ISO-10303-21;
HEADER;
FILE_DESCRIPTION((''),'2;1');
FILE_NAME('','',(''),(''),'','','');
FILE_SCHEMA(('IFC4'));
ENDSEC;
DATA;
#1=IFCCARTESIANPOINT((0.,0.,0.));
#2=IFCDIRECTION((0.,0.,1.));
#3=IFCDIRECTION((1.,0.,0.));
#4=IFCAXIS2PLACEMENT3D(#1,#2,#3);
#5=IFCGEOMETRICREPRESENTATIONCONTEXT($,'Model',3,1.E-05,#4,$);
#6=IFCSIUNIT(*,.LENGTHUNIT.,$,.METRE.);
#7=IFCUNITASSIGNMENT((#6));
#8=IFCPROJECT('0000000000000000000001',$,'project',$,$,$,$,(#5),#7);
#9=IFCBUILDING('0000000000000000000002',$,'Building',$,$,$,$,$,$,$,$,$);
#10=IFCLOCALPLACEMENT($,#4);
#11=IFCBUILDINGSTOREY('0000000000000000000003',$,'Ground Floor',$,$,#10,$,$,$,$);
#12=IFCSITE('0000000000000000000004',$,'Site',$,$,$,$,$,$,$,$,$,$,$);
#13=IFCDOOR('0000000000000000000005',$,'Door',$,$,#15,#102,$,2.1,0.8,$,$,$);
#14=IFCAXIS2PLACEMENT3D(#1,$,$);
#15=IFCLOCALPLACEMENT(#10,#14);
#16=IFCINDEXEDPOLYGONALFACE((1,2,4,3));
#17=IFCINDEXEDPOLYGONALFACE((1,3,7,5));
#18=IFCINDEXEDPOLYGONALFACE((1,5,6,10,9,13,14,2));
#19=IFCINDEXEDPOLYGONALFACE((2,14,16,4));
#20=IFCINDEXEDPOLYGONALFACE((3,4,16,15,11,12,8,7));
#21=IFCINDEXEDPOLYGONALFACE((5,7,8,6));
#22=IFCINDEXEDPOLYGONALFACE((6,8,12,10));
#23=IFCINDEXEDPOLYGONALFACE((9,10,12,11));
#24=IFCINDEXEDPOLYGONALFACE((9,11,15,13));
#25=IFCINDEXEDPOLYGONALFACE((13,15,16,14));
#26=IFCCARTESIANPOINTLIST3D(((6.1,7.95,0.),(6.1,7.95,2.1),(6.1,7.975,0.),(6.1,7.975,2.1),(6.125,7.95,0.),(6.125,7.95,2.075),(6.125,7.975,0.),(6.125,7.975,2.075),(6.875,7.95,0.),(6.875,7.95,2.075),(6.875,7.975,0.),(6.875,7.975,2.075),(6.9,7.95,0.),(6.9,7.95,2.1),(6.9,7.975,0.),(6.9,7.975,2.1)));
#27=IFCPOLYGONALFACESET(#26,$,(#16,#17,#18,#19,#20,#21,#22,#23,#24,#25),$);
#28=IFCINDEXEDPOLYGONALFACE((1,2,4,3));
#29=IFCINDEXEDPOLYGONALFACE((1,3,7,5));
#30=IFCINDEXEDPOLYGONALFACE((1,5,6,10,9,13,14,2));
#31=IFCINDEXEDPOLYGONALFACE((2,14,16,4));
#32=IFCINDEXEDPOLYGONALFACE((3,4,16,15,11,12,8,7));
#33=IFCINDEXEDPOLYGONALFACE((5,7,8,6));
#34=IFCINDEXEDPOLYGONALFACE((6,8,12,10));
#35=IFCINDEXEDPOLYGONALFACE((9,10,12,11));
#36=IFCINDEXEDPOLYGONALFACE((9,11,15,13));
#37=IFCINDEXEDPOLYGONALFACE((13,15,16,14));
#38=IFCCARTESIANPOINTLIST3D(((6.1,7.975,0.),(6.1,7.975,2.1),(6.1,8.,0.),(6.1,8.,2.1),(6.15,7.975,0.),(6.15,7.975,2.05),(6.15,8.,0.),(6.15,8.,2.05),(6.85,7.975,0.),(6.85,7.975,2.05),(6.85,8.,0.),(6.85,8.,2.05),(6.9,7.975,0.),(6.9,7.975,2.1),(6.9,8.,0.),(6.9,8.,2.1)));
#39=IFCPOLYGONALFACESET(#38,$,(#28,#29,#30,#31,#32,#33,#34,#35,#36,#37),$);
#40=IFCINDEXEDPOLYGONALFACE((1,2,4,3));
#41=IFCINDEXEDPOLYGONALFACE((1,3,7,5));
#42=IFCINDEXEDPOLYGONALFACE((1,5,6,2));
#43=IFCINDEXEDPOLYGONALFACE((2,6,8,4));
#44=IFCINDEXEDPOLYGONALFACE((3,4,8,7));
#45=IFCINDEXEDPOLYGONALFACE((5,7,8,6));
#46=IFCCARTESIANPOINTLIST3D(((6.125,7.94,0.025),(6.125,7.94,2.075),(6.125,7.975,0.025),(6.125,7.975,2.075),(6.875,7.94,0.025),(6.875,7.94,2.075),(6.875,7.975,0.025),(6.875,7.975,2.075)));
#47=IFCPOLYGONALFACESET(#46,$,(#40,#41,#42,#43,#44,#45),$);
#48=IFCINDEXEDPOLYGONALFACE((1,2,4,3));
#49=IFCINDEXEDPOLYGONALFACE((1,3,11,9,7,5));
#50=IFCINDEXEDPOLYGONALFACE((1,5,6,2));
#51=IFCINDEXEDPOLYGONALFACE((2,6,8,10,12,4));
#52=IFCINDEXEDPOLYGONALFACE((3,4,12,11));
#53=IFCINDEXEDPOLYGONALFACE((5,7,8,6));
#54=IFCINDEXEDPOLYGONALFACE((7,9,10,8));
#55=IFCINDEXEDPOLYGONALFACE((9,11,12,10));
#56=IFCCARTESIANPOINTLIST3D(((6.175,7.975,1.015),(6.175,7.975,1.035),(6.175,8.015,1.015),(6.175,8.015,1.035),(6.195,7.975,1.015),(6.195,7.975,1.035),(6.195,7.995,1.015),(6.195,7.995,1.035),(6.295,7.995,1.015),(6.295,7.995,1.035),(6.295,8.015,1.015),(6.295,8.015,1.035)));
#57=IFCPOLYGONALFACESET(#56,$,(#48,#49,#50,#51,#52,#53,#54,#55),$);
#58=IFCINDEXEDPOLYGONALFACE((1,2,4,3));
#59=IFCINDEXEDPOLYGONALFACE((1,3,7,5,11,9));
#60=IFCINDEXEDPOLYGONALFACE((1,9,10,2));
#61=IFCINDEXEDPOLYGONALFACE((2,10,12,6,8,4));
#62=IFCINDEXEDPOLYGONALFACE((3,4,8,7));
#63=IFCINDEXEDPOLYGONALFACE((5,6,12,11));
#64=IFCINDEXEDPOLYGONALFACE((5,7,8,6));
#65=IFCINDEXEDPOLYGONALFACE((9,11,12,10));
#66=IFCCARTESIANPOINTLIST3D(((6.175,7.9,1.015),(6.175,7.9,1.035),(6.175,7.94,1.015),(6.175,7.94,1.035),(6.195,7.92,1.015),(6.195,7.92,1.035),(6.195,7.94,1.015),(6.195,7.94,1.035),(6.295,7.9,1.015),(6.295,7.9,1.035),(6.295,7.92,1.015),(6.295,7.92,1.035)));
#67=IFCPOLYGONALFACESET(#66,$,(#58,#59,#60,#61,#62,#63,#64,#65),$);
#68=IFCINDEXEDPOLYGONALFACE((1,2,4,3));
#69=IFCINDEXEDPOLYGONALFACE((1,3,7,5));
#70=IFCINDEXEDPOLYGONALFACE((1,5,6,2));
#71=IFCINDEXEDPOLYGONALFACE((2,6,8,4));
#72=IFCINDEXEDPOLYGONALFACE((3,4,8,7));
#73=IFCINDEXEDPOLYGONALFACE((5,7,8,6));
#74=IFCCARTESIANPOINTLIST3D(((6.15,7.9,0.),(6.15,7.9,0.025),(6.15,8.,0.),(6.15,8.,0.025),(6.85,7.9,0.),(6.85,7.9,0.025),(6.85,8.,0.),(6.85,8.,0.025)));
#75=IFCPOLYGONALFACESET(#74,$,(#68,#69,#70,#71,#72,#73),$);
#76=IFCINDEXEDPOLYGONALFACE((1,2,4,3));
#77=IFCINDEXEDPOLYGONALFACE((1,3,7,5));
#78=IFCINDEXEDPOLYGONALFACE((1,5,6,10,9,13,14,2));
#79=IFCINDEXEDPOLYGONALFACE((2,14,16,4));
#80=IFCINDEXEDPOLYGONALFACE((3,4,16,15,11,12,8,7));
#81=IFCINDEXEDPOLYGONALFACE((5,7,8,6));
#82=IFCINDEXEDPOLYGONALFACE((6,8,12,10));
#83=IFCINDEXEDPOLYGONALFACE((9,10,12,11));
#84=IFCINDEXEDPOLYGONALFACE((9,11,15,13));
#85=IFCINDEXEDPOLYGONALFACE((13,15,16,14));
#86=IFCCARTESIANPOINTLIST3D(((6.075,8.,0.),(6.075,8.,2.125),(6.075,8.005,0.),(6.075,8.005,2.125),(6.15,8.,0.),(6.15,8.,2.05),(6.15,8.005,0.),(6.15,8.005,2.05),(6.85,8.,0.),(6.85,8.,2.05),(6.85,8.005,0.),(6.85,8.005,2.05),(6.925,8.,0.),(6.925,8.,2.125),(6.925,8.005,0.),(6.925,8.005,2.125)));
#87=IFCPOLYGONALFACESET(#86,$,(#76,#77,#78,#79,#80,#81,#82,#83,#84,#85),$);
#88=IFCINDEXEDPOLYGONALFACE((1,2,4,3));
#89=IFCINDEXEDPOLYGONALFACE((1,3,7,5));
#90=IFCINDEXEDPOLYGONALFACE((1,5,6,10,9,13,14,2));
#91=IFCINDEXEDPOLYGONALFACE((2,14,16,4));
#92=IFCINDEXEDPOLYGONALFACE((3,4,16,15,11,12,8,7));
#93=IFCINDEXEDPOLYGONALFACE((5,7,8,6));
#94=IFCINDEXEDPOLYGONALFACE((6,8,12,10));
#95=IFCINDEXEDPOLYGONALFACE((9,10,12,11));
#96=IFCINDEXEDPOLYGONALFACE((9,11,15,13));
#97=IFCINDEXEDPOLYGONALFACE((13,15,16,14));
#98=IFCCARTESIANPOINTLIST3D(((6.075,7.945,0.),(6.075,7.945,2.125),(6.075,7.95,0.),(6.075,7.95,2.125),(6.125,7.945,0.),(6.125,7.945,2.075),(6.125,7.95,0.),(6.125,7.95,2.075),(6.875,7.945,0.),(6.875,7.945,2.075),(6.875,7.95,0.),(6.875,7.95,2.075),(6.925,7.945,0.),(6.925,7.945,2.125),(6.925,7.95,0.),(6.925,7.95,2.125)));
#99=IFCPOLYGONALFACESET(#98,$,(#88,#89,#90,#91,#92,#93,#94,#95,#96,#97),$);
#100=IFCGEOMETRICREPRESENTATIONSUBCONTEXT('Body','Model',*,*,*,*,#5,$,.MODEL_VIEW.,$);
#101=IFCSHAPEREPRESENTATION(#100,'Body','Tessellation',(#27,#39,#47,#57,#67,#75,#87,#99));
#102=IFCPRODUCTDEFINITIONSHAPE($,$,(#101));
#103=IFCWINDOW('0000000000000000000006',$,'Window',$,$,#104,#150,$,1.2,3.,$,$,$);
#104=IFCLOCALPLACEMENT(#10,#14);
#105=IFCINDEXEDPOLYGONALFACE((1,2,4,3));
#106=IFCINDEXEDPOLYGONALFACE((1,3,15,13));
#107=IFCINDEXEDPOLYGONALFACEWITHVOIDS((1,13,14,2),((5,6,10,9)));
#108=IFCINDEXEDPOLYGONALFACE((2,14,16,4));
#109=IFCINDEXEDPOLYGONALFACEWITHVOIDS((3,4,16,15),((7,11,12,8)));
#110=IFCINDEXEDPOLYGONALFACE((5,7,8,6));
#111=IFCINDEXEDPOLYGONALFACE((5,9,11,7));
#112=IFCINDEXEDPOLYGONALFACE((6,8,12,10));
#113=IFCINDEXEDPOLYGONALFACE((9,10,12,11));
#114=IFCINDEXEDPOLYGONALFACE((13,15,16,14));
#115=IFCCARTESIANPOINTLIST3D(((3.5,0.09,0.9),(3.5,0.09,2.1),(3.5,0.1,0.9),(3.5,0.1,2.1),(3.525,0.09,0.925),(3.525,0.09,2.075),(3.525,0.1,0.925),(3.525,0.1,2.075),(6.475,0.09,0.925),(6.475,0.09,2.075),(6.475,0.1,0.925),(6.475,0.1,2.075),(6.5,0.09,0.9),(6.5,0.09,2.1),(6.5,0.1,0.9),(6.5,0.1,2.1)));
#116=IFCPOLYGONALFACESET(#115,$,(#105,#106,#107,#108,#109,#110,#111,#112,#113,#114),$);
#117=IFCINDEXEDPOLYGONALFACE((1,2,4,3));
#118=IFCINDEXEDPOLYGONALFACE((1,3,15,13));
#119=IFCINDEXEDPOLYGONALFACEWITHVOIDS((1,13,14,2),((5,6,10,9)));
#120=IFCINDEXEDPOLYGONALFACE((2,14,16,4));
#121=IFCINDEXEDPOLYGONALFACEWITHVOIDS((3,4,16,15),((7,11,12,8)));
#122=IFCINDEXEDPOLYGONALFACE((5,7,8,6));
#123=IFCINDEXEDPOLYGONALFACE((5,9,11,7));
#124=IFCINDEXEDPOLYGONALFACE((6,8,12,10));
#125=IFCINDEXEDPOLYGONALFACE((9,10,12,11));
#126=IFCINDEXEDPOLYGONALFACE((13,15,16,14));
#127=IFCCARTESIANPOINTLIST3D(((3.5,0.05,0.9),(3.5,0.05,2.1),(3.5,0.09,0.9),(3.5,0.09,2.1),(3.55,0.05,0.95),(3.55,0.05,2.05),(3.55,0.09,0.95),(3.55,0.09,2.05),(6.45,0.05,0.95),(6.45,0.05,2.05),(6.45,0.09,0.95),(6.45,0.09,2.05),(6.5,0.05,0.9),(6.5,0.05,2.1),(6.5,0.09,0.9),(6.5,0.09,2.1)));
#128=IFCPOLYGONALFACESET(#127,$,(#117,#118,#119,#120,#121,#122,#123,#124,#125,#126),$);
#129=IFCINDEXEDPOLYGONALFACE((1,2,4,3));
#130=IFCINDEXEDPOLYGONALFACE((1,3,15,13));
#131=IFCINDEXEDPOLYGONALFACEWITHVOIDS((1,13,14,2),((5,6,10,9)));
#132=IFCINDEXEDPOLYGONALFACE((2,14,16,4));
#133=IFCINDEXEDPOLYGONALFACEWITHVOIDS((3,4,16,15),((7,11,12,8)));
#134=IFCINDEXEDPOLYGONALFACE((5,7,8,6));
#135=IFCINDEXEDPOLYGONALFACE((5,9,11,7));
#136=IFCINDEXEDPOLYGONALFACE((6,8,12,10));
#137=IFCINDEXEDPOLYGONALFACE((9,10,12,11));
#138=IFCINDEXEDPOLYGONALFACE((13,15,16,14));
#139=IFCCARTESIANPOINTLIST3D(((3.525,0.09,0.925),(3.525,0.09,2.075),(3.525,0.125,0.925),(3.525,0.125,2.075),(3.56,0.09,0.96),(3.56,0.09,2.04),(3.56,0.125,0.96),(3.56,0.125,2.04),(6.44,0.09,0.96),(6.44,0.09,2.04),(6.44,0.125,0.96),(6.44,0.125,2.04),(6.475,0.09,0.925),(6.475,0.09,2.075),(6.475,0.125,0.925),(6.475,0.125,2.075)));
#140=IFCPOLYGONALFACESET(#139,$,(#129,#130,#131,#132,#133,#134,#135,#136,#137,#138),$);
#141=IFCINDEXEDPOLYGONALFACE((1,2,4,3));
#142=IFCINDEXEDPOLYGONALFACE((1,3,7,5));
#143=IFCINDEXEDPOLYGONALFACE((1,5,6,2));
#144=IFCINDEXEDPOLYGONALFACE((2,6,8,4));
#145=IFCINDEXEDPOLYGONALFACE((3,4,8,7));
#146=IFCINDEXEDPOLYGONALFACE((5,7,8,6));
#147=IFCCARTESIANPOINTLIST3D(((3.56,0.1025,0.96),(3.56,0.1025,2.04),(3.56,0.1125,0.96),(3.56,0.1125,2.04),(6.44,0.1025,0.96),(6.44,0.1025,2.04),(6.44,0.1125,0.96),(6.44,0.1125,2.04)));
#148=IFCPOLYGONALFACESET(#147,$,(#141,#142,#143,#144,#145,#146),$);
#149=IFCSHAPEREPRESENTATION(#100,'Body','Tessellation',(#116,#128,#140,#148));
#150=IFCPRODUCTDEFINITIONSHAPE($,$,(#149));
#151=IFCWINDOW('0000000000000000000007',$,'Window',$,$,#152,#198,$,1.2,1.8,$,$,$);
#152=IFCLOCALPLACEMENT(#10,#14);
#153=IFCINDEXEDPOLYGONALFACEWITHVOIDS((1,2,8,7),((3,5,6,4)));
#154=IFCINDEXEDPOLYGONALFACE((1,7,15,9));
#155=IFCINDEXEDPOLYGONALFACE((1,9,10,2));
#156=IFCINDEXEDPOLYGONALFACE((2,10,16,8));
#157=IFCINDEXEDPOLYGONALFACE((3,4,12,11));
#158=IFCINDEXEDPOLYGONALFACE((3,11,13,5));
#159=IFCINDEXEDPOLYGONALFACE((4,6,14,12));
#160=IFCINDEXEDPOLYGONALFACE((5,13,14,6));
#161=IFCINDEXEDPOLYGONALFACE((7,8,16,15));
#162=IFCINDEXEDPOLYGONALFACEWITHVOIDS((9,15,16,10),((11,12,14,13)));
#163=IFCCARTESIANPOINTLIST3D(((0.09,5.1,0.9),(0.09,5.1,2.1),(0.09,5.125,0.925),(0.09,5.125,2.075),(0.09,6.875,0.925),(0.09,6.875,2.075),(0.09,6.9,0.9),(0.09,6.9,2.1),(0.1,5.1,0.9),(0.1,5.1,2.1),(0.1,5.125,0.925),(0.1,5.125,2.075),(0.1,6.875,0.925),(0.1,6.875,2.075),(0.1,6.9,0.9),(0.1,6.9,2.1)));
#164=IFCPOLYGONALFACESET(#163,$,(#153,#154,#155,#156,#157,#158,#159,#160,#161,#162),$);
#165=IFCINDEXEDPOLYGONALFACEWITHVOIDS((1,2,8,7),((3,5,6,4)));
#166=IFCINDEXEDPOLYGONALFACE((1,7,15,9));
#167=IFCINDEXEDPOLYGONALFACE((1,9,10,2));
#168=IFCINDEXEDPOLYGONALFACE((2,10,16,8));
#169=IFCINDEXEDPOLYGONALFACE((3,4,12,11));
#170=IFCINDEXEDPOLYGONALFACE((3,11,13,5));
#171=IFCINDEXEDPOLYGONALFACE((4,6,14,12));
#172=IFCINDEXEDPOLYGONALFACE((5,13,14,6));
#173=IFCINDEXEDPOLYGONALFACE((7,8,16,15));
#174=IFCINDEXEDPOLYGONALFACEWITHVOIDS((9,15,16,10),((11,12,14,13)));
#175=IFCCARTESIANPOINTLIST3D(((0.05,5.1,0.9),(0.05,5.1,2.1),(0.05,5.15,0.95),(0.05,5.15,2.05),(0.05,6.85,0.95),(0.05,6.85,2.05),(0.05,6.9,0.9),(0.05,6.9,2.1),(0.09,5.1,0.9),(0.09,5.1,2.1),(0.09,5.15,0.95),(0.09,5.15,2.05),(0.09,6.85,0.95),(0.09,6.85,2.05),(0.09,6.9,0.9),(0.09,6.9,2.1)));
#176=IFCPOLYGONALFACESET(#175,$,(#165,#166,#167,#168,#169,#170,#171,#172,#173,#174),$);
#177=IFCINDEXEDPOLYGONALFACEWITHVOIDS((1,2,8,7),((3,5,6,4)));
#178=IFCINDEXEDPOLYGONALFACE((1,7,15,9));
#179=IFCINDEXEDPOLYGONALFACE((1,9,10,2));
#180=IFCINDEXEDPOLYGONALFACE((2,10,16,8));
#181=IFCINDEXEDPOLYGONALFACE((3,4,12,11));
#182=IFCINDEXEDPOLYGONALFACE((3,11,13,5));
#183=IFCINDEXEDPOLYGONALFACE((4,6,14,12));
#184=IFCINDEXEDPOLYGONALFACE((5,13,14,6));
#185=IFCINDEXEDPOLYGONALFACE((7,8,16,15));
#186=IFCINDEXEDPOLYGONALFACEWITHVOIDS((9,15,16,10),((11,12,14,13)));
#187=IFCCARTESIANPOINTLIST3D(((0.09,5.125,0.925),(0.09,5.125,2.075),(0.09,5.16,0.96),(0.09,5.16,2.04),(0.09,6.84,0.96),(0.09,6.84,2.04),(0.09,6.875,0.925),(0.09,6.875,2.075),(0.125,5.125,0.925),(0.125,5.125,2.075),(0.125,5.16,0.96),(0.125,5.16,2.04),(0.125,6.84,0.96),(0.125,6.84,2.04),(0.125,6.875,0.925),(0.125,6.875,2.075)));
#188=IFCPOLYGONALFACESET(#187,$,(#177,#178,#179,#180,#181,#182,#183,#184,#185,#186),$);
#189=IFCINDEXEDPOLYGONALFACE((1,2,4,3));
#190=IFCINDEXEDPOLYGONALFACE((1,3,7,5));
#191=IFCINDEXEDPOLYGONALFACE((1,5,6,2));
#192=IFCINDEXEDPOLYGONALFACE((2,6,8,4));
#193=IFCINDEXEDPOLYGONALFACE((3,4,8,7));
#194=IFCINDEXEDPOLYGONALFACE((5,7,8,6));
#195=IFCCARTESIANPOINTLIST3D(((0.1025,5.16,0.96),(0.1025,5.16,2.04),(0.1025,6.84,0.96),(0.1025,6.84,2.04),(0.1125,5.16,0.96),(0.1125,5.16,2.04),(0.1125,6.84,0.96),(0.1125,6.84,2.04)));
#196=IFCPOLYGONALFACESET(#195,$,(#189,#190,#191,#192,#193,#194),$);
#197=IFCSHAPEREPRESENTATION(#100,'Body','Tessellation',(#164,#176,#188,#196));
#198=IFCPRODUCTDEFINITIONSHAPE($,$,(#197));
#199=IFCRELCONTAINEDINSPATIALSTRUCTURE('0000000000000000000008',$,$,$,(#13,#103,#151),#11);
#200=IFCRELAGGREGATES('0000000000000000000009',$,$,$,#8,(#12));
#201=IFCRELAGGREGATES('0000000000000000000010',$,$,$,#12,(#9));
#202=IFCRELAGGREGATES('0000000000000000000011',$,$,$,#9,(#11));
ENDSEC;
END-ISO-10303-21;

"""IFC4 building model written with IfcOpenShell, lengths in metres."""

from ifc_helpers import new_model, si_unit, frame, origin_with_axes, place, context, subcontext, project, spatial, line, indexed_curve, outline, extrude, element, save


model = new_model("IFC4")

# Units and contexts
model_context = context("Model", 3, precision=1e-05, world=origin_with_axes())
body_context = subcontext(model_context, "Body", "Model", "MODEL_VIEW")
ifc_project = project(units=[si_unit("LENGTHUNIT", "METRE")], contexts=[model_context])

# Site, building, storey
site = spatial("IfcSite", under=ifc_project, Name="Site")
building = spatial("IfcBuilding", under=site, Name="Building")
storey_placement = place(None, origin_with_axes())
storey = spatial("IfcBuildingStorey", under=building, at=storey_placement, Name="Ground Floor")

# Door
door_1_placement = place(storey_placement, frame((6.9, 8.0, 0.0), z_axis=(0.0, 0.0, 1.0), x_axis=(-1.0, 0.0, 0.0)))
element("IfcDoor", 1, at=door_1_placement, inside=storey, Name="Door", OverallHeight=2.1, OverallWidth=0.8, context=body_context, shape_type="SweptSolid", body=[
    extrude(outline(indexed_curve([(0.0, 0.0), (0.0, 2.1), (0.8, 2.1), (0.8, 0.0), (0.775, 0.0), (0.775, 2.075), (0.025, 2.075), (0.025, 0.0)], segments=[line(1, 2, 3, 4, 5, 6, 7, 8, 1)])), frame((0.0, 0.025, 0.0), z_axis=(0.0, -1.0, 0.0), x_axis=(1.0, 0.0, 0.0)), (0.0, 0.0, -1.0), 0.025),
    extrude(outline(indexed_curve([(0.0, 0.0), (0.0, 2.1), (0.8, 2.1), (0.8, 0.0), (0.75, 0.0), (0.75, 2.05), (0.05, 2.05), (0.05, 0.0)], segments=[line(1, 2, 3, 4, 5, 6, 7, 8, 1)])), frame((0.0, 0.0, 0.0), z_axis=(0.0, -1.0, 0.0), x_axis=(1.0, 0.0, 0.0)), (0.0, 0.0, -1.0), 0.025),
    extrude(outline(indexed_curve([(0.0, 0.0), (0.75, 0.0), (0.75, 0.035), (0.0, 0.035)], segments=[line(1, 2, 3, 4, 1)])), frame((0.025, 0.025, 0.025), z_axis=(0.0, 0.0, 1.0), x_axis=(1.0, 0.0, 0.0)), (0.0, 0.0, 1.0), 2.05),
    extrude(outline(indexed_curve([(0.0, 0.0), (0.0, -0.04), (-0.12, -0.04), (-0.12, -0.02), (-0.02, -0.02), (-0.02, 0.0)], segments=[line(1, 2, 3, 4, 5, 6, 1)])), frame((0.725, 0.025, 1.015), z_axis=(0.0, 0.0, 1.0), x_axis=(1.0, 0.0, 0.0)), (0.0, 0.0, 1.0), 0.02),
    extrude(outline(indexed_curve([(0.0, 0.0), (0.0, 0.04), (-0.12, 0.04), (-0.12, 0.02), (-0.02, 0.02), (-0.02, 0.0)], segments=[line(1, 2, 3, 4, 5, 6, 1)])), frame((0.725, 0.06, 1.015), z_axis=(0.0, 0.0, 1.0), x_axis=(1.0, 0.0, 0.0)), (0.0, 0.0, 1.0), 0.02),
    extrude(outline(indexed_curve([(0.0, 0.0), (0.7, 0.0), (0.7, 0.1), (0.0, 0.1)], segments=[line(1, 2, 3, 4, 1)])), frame((0.05, 0.0, 0.0), z_axis=(0.0, 0.0, 1.0), x_axis=(1.0, 0.0, 0.0)), (0.0, 0.0, 1.0), 0.025),
    extrude(outline(indexed_curve([(0.0, 0.0), (0.0, 2.125), (0.85, 2.125), (0.85, 0.0), (0.775, 0.0), (0.775, 2.05), (0.075, 2.05), (0.075, 0.0)], segments=[line(1, 2, 3, 4, 5, 6, 7, 8, 1)])), frame((-0.025, -0.005, 0.0), z_axis=(0.0, -1.0, 0.0), x_axis=(1.0, 0.0, 0.0)), (0.0, 0.0, -1.0), 0.005),
    extrude(outline(indexed_curve([(0.0, 0.0), (0.0, 2.125), (0.85, 2.125), (0.85, 0.0), (0.8, 0.0), (0.8, 2.075), (0.05, 2.075), (0.05, 0.0)], segments=[line(1, 2, 3, 4, 5, 6, 7, 8, 1)])), frame((-0.025, 0.05, 0.0), z_axis=(0.0, -1.0, 0.0), x_axis=(1.0, 0.0, 0.0)), (0.0, 0.0, -1.0), 0.005),
])

# Windows
window_1_placement = place(storey_placement, frame((3.5, 0.0, 0.9), z_axis=(0.0, 0.0, 1.0), x_axis=(1.0, 0.0, 0.0)))
element("IfcWindow", 2, at=window_1_placement, inside=storey, Name="Window", OverallHeight=1.2, OverallWidth=3.0, context=body_context, shape_type="SweptSolid", body=[
    extrude(outline(indexed_curve([(0.0, 0.0), (3.0, 0.0), (3.0, 1.2), (0.0, 1.2)], segments=[line(1, 2, 3, 4, 1)]), holes=[indexed_curve([(0.025, 0.025), (2.975, 0.025), (2.975, 1.175), (0.025, 1.175)], segments=[line(1, 2, 3, 4, 1)])]), frame((0.0, 0.09, 0.0), z_axis=(0.0, -1.0, 0.0), x_axis=(1.0, 0.0, 0.0)), (0.0, 0.0, -1.0), 0.01),
    extrude(outline(indexed_curve([(0.0, 0.0), (3.0, 0.0), (3.0, 1.2), (0.0, 1.2)], segments=[line(1, 2, 3, 4, 1)]), holes=[indexed_curve([(0.05, 0.05), (2.95, 0.05), (2.95, 1.15), (0.05, 1.15)], segments=[line(1, 2, 3, 4, 1)])]), frame((0.0, 0.05, 0.0), z_axis=(0.0, -1.0, 0.0), x_axis=(1.0, 0.0, 0.0)), (0.0, 0.0, -1.0), 0.04),
    extrude(outline(indexed_curve([(0.0, 0.0), (2.95, 0.0), (2.95, 1.15), (0.0, 1.15)], segments=[line(1, 2, 3, 4, 1)]), holes=[indexed_curve([(0.035, 0.035), (2.915, 0.035), (2.915, 1.115), (0.035, 1.115)], segments=[line(1, 2, 3, 4, 1)])]), frame((0.025, 0.09, 0.025), z_axis=(0.0, -1.0, 0.0), x_axis=(1.0, 0.0, 0.0)), (0.0, 0.0, -1.0), 0.035),
    extrude(outline(indexed_curve([(0.035, 0.035), (2.915, 0.035), (2.915, 1.115), (0.035, 1.115)], segments=[line(1, 2, 3, 4, 1)])), frame((0.025, 0.1025, 0.025), z_axis=(0.0, -1.0, 0.0), x_axis=(1.0, 0.0, 0.0)), (0.0, 0.0, -1.0), 0.01),
])
for number, where, z_axis, x_axis, name in (
    (3, (0.0, 6.9, 0.9), (0.0, 0.0, 1.0), (0.0, -1.0, 0.0), "Window"),
):
    element("IfcWindow", number, at=place(storey_placement, frame(where, z_axis=z_axis, x_axis=x_axis)), inside=storey, Name=name, OverallHeight=1.2, OverallWidth=1.8, context=body_context, shape_type="SweptSolid", body=[
        extrude(outline(indexed_curve([(0.0, 0.0), (1.8, 0.0), (1.8, 1.2), (0.0, 1.2)], segments=[line(1, 2, 3, 4, 1)]), holes=[indexed_curve([(0.025, 0.025), (1.775, 0.025), (1.775, 1.175), (0.025, 1.175)], segments=[line(1, 2, 3, 4, 1)])]), frame((0.0, 0.09, 0.0), z_axis=(0.0, -1.0, 0.0), x_axis=(1.0, 0.0, 0.0)), (0.0, 0.0, -1.0), 0.01),
        extrude(outline(indexed_curve([(0.0, 0.0), (1.8, 0.0), (1.8, 1.2), (0.0, 1.2)], segments=[line(1, 2, 3, 4, 1)]), holes=[indexed_curve([(0.05, 0.05), (1.75, 0.05), (1.75, 1.15), (0.05, 1.15)], segments=[line(1, 2, 3, 4, 1)])]), frame((0.0, 0.05, 0.0), z_axis=(0.0, -1.0, 0.0), x_axis=(1.0, 0.0, 0.0)), (0.0, 0.0, -1.0), 0.04),
        extrude(outline(indexed_curve([(0.0, 0.0), (1.75, 0.0), (1.75, 1.15), (0.0, 1.15)], segments=[line(1, 2, 3, 4, 1)]), holes=[indexed_curve([(0.035, 0.035), (1.715, 0.035), (1.715, 1.115), (0.035, 1.115)], segments=[line(1, 2, 3, 4, 1)])]), frame((0.025, 0.09, 0.025), z_axis=(0.0, -1.0, 0.0), x_axis=(1.0, 0.0, 0.0)), (0.0, 0.0, -1.0), 0.035),
        extrude(outline(indexed_curve([(0.035, 0.035), (1.715, 0.035), (1.715, 1.115), (0.035, 1.115)], segments=[line(1, 2, 3, 4, 1)])), frame((0.025, 0.1025, 0.025), z_axis=(0.0, -1.0, 0.0), x_axis=(1.0, 0.0, 0.0)), (0.0, 0.0, -1.0), 0.01),
    ])

save(model, "model.ifc")
